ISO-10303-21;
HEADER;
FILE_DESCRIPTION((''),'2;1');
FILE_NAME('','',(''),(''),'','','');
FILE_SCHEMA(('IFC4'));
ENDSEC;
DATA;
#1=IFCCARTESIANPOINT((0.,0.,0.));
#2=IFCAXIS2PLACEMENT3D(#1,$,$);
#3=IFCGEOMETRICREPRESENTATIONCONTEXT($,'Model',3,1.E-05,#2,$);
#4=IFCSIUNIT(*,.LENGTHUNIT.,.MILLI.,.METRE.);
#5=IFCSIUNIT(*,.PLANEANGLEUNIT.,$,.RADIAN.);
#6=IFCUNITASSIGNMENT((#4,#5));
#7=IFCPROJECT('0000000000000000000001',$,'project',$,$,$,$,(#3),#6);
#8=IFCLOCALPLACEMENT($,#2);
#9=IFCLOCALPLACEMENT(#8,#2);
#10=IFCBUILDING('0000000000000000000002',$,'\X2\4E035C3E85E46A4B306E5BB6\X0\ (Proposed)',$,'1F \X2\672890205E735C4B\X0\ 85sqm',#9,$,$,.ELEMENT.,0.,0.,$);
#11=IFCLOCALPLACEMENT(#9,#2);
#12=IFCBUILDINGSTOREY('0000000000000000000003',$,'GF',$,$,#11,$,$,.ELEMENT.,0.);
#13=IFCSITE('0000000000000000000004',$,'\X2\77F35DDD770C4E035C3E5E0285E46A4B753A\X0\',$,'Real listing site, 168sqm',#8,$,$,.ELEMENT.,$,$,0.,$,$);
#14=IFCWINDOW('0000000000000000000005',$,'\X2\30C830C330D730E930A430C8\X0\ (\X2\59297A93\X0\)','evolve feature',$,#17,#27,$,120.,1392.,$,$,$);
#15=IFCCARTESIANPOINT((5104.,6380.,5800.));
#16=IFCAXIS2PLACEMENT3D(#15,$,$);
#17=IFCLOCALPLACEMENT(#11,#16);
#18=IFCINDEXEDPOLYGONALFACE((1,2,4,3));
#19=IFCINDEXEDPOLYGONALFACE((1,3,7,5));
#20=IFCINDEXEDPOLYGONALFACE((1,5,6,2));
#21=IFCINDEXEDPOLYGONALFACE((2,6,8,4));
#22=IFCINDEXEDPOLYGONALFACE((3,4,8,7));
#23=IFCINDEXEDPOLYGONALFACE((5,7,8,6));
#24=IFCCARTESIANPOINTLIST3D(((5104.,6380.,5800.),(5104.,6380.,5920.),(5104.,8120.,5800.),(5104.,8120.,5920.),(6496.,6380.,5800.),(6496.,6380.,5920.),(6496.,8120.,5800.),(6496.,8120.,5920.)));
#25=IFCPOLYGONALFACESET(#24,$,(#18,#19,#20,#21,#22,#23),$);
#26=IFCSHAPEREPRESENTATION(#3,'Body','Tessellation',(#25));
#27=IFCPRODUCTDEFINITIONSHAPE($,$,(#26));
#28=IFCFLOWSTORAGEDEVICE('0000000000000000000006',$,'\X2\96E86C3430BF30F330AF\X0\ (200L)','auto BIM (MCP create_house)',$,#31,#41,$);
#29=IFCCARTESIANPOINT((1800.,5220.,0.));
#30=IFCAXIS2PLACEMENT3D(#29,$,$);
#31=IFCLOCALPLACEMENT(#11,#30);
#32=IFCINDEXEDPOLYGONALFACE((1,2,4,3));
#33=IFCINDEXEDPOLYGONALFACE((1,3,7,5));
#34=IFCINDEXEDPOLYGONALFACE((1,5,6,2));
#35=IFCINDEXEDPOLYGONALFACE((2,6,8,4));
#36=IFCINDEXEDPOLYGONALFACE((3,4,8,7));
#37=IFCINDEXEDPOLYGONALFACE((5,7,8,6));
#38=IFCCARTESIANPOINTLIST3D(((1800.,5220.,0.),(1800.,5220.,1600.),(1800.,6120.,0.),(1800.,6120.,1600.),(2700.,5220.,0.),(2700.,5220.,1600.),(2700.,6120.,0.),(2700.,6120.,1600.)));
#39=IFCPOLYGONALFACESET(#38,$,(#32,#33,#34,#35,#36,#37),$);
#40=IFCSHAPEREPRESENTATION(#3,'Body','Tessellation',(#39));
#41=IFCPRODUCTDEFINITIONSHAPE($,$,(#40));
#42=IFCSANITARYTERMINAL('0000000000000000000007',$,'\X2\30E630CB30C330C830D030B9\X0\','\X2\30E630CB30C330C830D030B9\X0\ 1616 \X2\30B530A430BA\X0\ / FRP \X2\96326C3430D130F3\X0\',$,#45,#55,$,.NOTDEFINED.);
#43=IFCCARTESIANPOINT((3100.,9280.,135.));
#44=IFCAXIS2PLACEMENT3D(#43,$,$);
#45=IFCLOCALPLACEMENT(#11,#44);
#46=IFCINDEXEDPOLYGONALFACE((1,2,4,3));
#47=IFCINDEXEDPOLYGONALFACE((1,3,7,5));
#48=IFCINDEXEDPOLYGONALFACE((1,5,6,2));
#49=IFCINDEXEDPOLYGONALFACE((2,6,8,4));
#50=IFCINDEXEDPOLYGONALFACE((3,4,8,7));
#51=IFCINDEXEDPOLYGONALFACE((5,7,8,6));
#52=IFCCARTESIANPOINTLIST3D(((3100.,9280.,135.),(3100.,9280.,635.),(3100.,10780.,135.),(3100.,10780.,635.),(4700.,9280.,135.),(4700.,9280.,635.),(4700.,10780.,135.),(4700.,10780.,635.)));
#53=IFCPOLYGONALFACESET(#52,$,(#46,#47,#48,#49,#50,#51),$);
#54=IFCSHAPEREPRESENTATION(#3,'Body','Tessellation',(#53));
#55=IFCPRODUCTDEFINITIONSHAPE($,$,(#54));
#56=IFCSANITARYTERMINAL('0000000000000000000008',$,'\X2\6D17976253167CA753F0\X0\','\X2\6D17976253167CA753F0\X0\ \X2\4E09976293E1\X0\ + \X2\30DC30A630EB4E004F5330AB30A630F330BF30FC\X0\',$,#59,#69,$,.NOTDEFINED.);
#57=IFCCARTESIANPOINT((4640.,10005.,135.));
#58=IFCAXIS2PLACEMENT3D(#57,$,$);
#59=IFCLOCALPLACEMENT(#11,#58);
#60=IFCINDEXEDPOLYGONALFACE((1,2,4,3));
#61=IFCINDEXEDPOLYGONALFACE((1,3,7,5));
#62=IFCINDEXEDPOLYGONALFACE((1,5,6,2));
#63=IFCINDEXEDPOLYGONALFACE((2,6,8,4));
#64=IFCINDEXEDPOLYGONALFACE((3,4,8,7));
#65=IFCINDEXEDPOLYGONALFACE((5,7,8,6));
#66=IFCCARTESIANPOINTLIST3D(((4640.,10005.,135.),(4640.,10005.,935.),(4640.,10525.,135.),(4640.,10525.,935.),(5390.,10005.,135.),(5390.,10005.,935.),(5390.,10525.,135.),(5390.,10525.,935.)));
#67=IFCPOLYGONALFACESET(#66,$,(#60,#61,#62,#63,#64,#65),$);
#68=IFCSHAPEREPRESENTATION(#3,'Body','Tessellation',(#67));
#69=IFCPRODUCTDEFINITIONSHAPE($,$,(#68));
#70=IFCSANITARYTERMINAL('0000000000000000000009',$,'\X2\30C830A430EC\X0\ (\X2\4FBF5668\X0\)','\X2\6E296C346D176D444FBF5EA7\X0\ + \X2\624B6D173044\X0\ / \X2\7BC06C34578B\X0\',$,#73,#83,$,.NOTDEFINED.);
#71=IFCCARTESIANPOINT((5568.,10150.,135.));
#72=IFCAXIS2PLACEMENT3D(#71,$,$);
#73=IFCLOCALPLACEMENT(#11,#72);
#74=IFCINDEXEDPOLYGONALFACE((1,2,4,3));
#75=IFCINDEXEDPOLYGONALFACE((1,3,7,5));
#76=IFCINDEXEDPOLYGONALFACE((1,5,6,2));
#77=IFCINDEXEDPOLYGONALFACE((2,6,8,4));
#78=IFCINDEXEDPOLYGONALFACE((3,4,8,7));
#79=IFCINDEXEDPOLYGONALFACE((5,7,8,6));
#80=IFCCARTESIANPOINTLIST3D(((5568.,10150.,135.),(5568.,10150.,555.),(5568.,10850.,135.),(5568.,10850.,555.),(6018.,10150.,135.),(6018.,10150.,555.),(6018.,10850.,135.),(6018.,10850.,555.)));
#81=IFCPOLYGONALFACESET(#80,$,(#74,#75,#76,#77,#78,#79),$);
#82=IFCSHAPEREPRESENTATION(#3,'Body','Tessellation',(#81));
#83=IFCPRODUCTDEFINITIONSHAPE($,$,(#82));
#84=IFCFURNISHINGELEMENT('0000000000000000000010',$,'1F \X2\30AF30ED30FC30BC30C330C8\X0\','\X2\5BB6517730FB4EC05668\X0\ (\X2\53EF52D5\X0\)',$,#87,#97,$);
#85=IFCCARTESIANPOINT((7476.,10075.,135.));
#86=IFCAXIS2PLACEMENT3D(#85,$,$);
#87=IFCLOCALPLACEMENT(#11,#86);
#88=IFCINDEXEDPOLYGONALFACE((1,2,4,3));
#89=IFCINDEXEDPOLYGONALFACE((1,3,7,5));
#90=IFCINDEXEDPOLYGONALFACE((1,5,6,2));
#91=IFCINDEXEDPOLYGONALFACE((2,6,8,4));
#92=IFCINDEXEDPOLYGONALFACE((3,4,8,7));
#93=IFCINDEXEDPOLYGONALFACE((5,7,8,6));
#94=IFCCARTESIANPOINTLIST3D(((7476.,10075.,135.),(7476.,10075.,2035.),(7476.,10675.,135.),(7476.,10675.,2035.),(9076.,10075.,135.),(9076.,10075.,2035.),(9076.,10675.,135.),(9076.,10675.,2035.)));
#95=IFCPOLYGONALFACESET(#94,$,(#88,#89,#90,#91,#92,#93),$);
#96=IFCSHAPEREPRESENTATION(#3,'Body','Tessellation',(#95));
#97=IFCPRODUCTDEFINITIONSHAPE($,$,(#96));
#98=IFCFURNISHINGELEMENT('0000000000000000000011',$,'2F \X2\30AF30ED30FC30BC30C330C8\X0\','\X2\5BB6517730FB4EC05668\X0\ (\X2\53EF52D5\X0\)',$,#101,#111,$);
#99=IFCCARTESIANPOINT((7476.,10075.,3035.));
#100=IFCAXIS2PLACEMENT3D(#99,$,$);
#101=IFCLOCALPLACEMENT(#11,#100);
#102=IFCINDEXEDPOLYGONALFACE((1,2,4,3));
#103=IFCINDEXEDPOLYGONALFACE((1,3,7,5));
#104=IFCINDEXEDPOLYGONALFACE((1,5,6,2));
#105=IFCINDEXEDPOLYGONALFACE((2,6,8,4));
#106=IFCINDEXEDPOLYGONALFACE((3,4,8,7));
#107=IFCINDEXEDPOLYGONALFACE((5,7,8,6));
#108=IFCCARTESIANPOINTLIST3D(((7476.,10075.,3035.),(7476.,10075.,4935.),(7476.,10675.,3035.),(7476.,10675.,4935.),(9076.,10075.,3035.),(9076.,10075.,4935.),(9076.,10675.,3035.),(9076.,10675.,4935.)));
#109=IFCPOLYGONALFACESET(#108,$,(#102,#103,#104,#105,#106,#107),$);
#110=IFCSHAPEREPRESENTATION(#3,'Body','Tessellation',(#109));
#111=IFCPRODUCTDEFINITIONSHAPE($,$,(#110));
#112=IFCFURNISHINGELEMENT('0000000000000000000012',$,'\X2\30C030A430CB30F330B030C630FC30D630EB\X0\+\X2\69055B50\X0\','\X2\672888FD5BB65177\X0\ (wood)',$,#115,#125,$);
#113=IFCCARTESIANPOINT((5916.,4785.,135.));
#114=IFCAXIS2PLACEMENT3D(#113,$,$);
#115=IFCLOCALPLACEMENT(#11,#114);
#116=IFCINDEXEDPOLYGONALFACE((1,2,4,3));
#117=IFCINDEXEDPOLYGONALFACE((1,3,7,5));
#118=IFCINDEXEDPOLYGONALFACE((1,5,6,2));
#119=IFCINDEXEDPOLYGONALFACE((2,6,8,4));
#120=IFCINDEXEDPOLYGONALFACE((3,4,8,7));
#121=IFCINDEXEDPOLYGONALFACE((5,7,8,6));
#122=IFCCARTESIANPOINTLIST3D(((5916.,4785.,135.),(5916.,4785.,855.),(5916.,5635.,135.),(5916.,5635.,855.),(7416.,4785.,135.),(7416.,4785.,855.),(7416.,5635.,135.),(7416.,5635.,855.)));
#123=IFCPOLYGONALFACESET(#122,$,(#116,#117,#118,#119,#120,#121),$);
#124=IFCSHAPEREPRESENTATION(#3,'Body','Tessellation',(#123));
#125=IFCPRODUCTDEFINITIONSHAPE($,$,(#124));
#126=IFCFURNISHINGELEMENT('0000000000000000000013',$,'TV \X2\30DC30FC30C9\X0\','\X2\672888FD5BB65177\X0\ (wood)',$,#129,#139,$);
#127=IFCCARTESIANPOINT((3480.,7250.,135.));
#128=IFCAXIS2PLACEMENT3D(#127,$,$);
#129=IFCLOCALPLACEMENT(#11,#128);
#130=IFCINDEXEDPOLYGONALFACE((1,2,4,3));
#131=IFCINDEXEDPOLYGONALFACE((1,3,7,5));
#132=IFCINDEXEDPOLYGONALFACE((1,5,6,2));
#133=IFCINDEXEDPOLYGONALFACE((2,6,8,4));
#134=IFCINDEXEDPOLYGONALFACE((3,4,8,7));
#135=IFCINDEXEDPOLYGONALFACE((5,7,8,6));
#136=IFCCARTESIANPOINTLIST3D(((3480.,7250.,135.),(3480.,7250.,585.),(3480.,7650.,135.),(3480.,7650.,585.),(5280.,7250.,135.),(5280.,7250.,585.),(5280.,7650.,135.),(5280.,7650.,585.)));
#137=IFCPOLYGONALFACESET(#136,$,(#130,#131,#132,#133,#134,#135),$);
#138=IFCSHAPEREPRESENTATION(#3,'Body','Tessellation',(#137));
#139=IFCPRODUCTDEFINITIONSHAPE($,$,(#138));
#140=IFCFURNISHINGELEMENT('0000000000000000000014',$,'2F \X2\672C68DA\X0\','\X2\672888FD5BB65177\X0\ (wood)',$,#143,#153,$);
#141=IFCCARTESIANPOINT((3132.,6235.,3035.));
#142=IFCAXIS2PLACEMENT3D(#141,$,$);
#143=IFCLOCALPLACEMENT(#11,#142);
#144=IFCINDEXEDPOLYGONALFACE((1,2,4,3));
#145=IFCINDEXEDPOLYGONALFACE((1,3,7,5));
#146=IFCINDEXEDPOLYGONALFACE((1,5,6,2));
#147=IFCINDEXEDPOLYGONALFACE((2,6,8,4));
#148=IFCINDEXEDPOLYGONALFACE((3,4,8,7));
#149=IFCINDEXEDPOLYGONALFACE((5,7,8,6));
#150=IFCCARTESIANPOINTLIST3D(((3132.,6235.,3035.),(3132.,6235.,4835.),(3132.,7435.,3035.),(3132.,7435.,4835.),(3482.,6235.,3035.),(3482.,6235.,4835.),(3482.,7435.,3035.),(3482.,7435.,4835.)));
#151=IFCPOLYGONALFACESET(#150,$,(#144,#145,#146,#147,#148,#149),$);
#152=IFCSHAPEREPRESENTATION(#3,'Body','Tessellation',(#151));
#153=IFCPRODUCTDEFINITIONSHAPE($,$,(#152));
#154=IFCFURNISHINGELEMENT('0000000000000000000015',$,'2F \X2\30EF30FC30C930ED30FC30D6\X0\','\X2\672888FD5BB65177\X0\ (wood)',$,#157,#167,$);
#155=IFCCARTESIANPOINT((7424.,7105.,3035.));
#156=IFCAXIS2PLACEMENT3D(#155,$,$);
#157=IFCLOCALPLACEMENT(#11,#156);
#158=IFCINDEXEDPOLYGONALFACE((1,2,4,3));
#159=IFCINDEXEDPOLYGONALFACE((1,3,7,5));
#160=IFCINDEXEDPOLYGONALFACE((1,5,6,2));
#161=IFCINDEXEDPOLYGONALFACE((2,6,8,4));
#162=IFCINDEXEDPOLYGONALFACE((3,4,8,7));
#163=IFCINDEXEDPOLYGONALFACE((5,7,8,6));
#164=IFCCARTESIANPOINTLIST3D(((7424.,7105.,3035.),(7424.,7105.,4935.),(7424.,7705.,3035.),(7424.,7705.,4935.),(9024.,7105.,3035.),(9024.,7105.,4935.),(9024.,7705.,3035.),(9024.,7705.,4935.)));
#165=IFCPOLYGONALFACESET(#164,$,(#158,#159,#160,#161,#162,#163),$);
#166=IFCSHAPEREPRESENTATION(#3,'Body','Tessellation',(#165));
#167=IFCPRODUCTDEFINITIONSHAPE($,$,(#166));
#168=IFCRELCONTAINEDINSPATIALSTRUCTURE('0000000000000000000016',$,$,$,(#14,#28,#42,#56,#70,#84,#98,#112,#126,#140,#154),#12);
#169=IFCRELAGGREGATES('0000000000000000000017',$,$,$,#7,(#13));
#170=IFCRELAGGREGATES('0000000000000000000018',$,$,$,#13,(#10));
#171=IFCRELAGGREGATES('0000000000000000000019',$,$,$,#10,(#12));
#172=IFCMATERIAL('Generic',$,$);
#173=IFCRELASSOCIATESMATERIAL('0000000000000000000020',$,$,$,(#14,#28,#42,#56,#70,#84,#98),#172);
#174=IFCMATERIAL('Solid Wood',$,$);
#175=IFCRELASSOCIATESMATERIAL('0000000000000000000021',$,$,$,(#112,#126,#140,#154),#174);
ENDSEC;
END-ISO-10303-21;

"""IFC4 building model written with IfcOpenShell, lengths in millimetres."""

from ifc_helpers import new_model, si_unit, frame, frame_2d, origin, place, context, project, spatial, rectangle, extrude, material, element, save


model = new_model("IFC4")

# Units and contexts
model_context = context("Model", 3, precision=1e-05, world=origin())
ifc_project = project(units=[si_unit("LENGTHUNIT", "METRE", prefix="MILLI"), si_unit("PLANEANGLEUNIT", "RADIAN")], contexts=[model_context])

# Site, building, storey
site_placement = place(None, origin())
site = spatial("IfcSite", under=ifc_project, at=site_placement, Name="石川県七尾市藤橋町", ObjectType="Real listing site, 168sqm", CompositionType="ELEMENT", RefElevation=0.0)
building_placement = place(site_placement, origin())
building = spatial("IfcBuilding", under=site, at=building_placement, Name="七尾藤橋の家 (Proposed)", ObjectType="1F 木造平屋 85sqm", CompositionType="ELEMENT", ElevationOfRefHeight=0.0, ElevationOfTerrain=0.0)
storey_placement = place(building_placement, origin())
storey = spatial("IfcBuildingStorey", under=building, at=storey_placement, Name="GF", CompositionType="ELEMENT", Elevation=0.0)

# Shared definitions
ifc_material_1 = material(Name="Solid Wood")

# Window
ifc_material_2 = material(Name="Generic")
window_1_placement = place(storey_placement, frame((5104.0, 6380.0, 5800.0)))
element("IfcWindow", 1, at=window_1_placement, inside=storey, material=ifc_material_2, Name="トップライト (天窓)", Description="evolve feature", OverallHeight=120.0, OverallWidth=1392.0, context=model_context, shape_type="SweptSolid", body=[
    extrude(rectangle(XDim=1392.0, YDim=1740.0, at=frame_2d((696.0, 870.0))), frame((5104.0, 6380.0, 5800.0)), (0.0, 0.0, 1.0), 120.0),
])

# Flow storage device
flow_storage_device_placement = place(storey_placement, frame((1800.0, 5220.0, 0.0)))
element("IfcFlowStorageDevice", 2, at=flow_storage_device_placement, inside=storey, material=ifc_material_2, Name="雨水タンク (200L)", Description="auto BIM (MCP create_house)", context=model_context, shape_type="SweptSolid", body=[
    extrude(rectangle(XDim=900.0, YDim=900.0, at=frame_2d((450.0, 450.0))), frame((1800.0, 5220.0, 0.0)), (0.0, 0.0, 1.0), 1600.0),
])

# Sanitary terminals
sanitary_terminal_1_placement = place(storey_placement, frame((3100.0, 9280.0, 135.0)))
element("IfcSanitaryTerminal", 3, at=sanitary_terminal_1_placement, inside=storey, material=ifc_material_2, Name="ユニットバス", Description="ユニットバス 1616 サイズ / FRP 防水パン", PredefinedType="NOTDEFINED", context=model_context, shape_type="SweptSolid", body=[
    extrude(rectangle(XDim=1600.0, YDim=1500.0, at=frame_2d((800.0, 750.0))), frame((3100.0, 9280.0, 135.0)), (0.0, 0.0, 1.0), 500.0),
])
sanitary_terminal_2_placement = place(storey_placement, frame((4640.0, 10005.0, 135.0)))
element("IfcSanitaryTerminal", 4, at=sanitary_terminal_2_placement, inside=storey, material=ifc_material_2, Name="洗面化粧台", Description="洗面化粧台 三面鏡 + ボウル一体カウンター", PredefinedType="NOTDEFINED", context=model_context, shape_type="SweptSolid", body=[
    extrude(rectangle(XDim=750.0, YDim=520.0, at=frame_2d((375.0, 260.0))), frame((4640.0, 10005.0, 135.0)), (0.0, 0.0, 1.0), 800.0),
])
sanitary_terminal_3_placement = place(storey_placement, frame((5568.0, 10150.0, 135.0)))
element("IfcSanitaryTerminal", 5, at=sanitary_terminal_3_placement, inside=storey, material=ifc_material_2, Name="トイレ (便器)", Description="温水洗浄便座 + 手洗い / 節水型", PredefinedType="NOTDEFINED", context=model_context, shape_type="SweptSolid", body=[
    extrude(rectangle(XDim=450.0, YDim=700.0, at=frame_2d((225.0, 350.0))), frame((5568.0, 10150.0, 135.0)), (0.0, 0.0, 1.0), 420.0),
])

# Furnishing elements
furnishing_1_placement = place(storey_placement, frame((7476.0, 10075.0, 135.0)))
element("IfcFurnishingElement", 6, at=furnishing_1_placement, inside=storey, material=ifc_material_2, Name="1F クローゼット", Description="家具・什器 (可動)", context=model_context, shape_type="SweptSolid", body=[
    extrude(rectangle(XDim=1600.0, YDim=600.0, at=frame_2d((800.0, 300.0))), frame((7476.0, 10075.0, 135.0)), (0.0, 0.0, 1.0), 1900.0),
])
furnishing_2_placement = place(storey_placement, frame((7476.0, 10075.0, 3035.0)))
element("IfcFurnishingElement", 7, at=furnishing_2_placement, inside=storey, material=ifc_material_2, Name="2F クローゼット", Description="家具・什器 (可動)", context=model_context, shape_type="SweptSolid", body=[
    extrude(rectangle(XDim=1600.0, YDim=600.0, at=frame_2d((800.0, 300.0))), frame((7476.0, 10075.0, 3035.0)), (0.0, 0.0, 1.0), 1900.0),
])
furnishing_3_placement = place(storey_placement, frame((5916.0, 4785.0, 135.0)))
element("IfcFurnishingElement", 8, at=furnishing_3_placement, inside=storey, material=ifc_material_1, Name="ダイニングテーブル+椅子", Description="木製家具 (wood)", context=model_context, shape_type="SweptSolid", body=[
    extrude(rectangle(XDim=1500.0, YDim=850.0, at=frame_2d((750.0, 425.0))), frame((5916.0, 4785.0, 135.0)), (0.0, 0.0, 1.0), 720.0),
])
furnishing_4_placement = place(storey_placement, frame((3480.0, 7250.0, 135.0)))
element("IfcFurnishingElement", 9, at=furnishing_4_placement, inside=storey, material=ifc_material_1, Name="TV ボード", Description="木製家具 (wood)", context=model_context, shape_type="SweptSolid", body=[
    extrude(rectangle(XDim=1800.0, YDim=400.0, at=frame_2d((900.0, 200.0))), frame((3480.0, 7250.0, 135.0)), (0.0, 0.0, 1.0), 450.0),
])
furnishing_5_placement = place(storey_placement, frame((3132.0, 6235.0, 3035.0)))
element("IfcFurnishingElement", 10, at=furnishing_5_placement, inside=storey, material=ifc_material_1, Name="2F 本棚", Description="木製家具 (wood)", context=model_context, shape_type="SweptSolid", body=[
    extrude(rectangle(XDim=350.0, YDim=1200.0, at=frame_2d((175.0, 600.0))), frame((3132.0, 6235.0, 3035.0)), (0.0, 0.0, 1.0), 1800.0),
])
furnishing_6_placement = place(storey_placement, frame((7424.0, 7105.0, 3035.0)))
element("IfcFurnishingElement", 11, at=furnishing_6_placement, inside=storey, material=ifc_material_1, Name="2F ワードローブ", Description="木製家具 (wood)", context=model_context, shape_type="SweptSolid", body=[
    extrude(rectangle(XDim=1600.0, YDim=600.0, at=frame_2d((800.0, 300.0))), frame((7424.0, 7105.0, 3035.0)), (0.0, 0.0, 1.0), 1900.0),
])

save(model, "model.ifc")
